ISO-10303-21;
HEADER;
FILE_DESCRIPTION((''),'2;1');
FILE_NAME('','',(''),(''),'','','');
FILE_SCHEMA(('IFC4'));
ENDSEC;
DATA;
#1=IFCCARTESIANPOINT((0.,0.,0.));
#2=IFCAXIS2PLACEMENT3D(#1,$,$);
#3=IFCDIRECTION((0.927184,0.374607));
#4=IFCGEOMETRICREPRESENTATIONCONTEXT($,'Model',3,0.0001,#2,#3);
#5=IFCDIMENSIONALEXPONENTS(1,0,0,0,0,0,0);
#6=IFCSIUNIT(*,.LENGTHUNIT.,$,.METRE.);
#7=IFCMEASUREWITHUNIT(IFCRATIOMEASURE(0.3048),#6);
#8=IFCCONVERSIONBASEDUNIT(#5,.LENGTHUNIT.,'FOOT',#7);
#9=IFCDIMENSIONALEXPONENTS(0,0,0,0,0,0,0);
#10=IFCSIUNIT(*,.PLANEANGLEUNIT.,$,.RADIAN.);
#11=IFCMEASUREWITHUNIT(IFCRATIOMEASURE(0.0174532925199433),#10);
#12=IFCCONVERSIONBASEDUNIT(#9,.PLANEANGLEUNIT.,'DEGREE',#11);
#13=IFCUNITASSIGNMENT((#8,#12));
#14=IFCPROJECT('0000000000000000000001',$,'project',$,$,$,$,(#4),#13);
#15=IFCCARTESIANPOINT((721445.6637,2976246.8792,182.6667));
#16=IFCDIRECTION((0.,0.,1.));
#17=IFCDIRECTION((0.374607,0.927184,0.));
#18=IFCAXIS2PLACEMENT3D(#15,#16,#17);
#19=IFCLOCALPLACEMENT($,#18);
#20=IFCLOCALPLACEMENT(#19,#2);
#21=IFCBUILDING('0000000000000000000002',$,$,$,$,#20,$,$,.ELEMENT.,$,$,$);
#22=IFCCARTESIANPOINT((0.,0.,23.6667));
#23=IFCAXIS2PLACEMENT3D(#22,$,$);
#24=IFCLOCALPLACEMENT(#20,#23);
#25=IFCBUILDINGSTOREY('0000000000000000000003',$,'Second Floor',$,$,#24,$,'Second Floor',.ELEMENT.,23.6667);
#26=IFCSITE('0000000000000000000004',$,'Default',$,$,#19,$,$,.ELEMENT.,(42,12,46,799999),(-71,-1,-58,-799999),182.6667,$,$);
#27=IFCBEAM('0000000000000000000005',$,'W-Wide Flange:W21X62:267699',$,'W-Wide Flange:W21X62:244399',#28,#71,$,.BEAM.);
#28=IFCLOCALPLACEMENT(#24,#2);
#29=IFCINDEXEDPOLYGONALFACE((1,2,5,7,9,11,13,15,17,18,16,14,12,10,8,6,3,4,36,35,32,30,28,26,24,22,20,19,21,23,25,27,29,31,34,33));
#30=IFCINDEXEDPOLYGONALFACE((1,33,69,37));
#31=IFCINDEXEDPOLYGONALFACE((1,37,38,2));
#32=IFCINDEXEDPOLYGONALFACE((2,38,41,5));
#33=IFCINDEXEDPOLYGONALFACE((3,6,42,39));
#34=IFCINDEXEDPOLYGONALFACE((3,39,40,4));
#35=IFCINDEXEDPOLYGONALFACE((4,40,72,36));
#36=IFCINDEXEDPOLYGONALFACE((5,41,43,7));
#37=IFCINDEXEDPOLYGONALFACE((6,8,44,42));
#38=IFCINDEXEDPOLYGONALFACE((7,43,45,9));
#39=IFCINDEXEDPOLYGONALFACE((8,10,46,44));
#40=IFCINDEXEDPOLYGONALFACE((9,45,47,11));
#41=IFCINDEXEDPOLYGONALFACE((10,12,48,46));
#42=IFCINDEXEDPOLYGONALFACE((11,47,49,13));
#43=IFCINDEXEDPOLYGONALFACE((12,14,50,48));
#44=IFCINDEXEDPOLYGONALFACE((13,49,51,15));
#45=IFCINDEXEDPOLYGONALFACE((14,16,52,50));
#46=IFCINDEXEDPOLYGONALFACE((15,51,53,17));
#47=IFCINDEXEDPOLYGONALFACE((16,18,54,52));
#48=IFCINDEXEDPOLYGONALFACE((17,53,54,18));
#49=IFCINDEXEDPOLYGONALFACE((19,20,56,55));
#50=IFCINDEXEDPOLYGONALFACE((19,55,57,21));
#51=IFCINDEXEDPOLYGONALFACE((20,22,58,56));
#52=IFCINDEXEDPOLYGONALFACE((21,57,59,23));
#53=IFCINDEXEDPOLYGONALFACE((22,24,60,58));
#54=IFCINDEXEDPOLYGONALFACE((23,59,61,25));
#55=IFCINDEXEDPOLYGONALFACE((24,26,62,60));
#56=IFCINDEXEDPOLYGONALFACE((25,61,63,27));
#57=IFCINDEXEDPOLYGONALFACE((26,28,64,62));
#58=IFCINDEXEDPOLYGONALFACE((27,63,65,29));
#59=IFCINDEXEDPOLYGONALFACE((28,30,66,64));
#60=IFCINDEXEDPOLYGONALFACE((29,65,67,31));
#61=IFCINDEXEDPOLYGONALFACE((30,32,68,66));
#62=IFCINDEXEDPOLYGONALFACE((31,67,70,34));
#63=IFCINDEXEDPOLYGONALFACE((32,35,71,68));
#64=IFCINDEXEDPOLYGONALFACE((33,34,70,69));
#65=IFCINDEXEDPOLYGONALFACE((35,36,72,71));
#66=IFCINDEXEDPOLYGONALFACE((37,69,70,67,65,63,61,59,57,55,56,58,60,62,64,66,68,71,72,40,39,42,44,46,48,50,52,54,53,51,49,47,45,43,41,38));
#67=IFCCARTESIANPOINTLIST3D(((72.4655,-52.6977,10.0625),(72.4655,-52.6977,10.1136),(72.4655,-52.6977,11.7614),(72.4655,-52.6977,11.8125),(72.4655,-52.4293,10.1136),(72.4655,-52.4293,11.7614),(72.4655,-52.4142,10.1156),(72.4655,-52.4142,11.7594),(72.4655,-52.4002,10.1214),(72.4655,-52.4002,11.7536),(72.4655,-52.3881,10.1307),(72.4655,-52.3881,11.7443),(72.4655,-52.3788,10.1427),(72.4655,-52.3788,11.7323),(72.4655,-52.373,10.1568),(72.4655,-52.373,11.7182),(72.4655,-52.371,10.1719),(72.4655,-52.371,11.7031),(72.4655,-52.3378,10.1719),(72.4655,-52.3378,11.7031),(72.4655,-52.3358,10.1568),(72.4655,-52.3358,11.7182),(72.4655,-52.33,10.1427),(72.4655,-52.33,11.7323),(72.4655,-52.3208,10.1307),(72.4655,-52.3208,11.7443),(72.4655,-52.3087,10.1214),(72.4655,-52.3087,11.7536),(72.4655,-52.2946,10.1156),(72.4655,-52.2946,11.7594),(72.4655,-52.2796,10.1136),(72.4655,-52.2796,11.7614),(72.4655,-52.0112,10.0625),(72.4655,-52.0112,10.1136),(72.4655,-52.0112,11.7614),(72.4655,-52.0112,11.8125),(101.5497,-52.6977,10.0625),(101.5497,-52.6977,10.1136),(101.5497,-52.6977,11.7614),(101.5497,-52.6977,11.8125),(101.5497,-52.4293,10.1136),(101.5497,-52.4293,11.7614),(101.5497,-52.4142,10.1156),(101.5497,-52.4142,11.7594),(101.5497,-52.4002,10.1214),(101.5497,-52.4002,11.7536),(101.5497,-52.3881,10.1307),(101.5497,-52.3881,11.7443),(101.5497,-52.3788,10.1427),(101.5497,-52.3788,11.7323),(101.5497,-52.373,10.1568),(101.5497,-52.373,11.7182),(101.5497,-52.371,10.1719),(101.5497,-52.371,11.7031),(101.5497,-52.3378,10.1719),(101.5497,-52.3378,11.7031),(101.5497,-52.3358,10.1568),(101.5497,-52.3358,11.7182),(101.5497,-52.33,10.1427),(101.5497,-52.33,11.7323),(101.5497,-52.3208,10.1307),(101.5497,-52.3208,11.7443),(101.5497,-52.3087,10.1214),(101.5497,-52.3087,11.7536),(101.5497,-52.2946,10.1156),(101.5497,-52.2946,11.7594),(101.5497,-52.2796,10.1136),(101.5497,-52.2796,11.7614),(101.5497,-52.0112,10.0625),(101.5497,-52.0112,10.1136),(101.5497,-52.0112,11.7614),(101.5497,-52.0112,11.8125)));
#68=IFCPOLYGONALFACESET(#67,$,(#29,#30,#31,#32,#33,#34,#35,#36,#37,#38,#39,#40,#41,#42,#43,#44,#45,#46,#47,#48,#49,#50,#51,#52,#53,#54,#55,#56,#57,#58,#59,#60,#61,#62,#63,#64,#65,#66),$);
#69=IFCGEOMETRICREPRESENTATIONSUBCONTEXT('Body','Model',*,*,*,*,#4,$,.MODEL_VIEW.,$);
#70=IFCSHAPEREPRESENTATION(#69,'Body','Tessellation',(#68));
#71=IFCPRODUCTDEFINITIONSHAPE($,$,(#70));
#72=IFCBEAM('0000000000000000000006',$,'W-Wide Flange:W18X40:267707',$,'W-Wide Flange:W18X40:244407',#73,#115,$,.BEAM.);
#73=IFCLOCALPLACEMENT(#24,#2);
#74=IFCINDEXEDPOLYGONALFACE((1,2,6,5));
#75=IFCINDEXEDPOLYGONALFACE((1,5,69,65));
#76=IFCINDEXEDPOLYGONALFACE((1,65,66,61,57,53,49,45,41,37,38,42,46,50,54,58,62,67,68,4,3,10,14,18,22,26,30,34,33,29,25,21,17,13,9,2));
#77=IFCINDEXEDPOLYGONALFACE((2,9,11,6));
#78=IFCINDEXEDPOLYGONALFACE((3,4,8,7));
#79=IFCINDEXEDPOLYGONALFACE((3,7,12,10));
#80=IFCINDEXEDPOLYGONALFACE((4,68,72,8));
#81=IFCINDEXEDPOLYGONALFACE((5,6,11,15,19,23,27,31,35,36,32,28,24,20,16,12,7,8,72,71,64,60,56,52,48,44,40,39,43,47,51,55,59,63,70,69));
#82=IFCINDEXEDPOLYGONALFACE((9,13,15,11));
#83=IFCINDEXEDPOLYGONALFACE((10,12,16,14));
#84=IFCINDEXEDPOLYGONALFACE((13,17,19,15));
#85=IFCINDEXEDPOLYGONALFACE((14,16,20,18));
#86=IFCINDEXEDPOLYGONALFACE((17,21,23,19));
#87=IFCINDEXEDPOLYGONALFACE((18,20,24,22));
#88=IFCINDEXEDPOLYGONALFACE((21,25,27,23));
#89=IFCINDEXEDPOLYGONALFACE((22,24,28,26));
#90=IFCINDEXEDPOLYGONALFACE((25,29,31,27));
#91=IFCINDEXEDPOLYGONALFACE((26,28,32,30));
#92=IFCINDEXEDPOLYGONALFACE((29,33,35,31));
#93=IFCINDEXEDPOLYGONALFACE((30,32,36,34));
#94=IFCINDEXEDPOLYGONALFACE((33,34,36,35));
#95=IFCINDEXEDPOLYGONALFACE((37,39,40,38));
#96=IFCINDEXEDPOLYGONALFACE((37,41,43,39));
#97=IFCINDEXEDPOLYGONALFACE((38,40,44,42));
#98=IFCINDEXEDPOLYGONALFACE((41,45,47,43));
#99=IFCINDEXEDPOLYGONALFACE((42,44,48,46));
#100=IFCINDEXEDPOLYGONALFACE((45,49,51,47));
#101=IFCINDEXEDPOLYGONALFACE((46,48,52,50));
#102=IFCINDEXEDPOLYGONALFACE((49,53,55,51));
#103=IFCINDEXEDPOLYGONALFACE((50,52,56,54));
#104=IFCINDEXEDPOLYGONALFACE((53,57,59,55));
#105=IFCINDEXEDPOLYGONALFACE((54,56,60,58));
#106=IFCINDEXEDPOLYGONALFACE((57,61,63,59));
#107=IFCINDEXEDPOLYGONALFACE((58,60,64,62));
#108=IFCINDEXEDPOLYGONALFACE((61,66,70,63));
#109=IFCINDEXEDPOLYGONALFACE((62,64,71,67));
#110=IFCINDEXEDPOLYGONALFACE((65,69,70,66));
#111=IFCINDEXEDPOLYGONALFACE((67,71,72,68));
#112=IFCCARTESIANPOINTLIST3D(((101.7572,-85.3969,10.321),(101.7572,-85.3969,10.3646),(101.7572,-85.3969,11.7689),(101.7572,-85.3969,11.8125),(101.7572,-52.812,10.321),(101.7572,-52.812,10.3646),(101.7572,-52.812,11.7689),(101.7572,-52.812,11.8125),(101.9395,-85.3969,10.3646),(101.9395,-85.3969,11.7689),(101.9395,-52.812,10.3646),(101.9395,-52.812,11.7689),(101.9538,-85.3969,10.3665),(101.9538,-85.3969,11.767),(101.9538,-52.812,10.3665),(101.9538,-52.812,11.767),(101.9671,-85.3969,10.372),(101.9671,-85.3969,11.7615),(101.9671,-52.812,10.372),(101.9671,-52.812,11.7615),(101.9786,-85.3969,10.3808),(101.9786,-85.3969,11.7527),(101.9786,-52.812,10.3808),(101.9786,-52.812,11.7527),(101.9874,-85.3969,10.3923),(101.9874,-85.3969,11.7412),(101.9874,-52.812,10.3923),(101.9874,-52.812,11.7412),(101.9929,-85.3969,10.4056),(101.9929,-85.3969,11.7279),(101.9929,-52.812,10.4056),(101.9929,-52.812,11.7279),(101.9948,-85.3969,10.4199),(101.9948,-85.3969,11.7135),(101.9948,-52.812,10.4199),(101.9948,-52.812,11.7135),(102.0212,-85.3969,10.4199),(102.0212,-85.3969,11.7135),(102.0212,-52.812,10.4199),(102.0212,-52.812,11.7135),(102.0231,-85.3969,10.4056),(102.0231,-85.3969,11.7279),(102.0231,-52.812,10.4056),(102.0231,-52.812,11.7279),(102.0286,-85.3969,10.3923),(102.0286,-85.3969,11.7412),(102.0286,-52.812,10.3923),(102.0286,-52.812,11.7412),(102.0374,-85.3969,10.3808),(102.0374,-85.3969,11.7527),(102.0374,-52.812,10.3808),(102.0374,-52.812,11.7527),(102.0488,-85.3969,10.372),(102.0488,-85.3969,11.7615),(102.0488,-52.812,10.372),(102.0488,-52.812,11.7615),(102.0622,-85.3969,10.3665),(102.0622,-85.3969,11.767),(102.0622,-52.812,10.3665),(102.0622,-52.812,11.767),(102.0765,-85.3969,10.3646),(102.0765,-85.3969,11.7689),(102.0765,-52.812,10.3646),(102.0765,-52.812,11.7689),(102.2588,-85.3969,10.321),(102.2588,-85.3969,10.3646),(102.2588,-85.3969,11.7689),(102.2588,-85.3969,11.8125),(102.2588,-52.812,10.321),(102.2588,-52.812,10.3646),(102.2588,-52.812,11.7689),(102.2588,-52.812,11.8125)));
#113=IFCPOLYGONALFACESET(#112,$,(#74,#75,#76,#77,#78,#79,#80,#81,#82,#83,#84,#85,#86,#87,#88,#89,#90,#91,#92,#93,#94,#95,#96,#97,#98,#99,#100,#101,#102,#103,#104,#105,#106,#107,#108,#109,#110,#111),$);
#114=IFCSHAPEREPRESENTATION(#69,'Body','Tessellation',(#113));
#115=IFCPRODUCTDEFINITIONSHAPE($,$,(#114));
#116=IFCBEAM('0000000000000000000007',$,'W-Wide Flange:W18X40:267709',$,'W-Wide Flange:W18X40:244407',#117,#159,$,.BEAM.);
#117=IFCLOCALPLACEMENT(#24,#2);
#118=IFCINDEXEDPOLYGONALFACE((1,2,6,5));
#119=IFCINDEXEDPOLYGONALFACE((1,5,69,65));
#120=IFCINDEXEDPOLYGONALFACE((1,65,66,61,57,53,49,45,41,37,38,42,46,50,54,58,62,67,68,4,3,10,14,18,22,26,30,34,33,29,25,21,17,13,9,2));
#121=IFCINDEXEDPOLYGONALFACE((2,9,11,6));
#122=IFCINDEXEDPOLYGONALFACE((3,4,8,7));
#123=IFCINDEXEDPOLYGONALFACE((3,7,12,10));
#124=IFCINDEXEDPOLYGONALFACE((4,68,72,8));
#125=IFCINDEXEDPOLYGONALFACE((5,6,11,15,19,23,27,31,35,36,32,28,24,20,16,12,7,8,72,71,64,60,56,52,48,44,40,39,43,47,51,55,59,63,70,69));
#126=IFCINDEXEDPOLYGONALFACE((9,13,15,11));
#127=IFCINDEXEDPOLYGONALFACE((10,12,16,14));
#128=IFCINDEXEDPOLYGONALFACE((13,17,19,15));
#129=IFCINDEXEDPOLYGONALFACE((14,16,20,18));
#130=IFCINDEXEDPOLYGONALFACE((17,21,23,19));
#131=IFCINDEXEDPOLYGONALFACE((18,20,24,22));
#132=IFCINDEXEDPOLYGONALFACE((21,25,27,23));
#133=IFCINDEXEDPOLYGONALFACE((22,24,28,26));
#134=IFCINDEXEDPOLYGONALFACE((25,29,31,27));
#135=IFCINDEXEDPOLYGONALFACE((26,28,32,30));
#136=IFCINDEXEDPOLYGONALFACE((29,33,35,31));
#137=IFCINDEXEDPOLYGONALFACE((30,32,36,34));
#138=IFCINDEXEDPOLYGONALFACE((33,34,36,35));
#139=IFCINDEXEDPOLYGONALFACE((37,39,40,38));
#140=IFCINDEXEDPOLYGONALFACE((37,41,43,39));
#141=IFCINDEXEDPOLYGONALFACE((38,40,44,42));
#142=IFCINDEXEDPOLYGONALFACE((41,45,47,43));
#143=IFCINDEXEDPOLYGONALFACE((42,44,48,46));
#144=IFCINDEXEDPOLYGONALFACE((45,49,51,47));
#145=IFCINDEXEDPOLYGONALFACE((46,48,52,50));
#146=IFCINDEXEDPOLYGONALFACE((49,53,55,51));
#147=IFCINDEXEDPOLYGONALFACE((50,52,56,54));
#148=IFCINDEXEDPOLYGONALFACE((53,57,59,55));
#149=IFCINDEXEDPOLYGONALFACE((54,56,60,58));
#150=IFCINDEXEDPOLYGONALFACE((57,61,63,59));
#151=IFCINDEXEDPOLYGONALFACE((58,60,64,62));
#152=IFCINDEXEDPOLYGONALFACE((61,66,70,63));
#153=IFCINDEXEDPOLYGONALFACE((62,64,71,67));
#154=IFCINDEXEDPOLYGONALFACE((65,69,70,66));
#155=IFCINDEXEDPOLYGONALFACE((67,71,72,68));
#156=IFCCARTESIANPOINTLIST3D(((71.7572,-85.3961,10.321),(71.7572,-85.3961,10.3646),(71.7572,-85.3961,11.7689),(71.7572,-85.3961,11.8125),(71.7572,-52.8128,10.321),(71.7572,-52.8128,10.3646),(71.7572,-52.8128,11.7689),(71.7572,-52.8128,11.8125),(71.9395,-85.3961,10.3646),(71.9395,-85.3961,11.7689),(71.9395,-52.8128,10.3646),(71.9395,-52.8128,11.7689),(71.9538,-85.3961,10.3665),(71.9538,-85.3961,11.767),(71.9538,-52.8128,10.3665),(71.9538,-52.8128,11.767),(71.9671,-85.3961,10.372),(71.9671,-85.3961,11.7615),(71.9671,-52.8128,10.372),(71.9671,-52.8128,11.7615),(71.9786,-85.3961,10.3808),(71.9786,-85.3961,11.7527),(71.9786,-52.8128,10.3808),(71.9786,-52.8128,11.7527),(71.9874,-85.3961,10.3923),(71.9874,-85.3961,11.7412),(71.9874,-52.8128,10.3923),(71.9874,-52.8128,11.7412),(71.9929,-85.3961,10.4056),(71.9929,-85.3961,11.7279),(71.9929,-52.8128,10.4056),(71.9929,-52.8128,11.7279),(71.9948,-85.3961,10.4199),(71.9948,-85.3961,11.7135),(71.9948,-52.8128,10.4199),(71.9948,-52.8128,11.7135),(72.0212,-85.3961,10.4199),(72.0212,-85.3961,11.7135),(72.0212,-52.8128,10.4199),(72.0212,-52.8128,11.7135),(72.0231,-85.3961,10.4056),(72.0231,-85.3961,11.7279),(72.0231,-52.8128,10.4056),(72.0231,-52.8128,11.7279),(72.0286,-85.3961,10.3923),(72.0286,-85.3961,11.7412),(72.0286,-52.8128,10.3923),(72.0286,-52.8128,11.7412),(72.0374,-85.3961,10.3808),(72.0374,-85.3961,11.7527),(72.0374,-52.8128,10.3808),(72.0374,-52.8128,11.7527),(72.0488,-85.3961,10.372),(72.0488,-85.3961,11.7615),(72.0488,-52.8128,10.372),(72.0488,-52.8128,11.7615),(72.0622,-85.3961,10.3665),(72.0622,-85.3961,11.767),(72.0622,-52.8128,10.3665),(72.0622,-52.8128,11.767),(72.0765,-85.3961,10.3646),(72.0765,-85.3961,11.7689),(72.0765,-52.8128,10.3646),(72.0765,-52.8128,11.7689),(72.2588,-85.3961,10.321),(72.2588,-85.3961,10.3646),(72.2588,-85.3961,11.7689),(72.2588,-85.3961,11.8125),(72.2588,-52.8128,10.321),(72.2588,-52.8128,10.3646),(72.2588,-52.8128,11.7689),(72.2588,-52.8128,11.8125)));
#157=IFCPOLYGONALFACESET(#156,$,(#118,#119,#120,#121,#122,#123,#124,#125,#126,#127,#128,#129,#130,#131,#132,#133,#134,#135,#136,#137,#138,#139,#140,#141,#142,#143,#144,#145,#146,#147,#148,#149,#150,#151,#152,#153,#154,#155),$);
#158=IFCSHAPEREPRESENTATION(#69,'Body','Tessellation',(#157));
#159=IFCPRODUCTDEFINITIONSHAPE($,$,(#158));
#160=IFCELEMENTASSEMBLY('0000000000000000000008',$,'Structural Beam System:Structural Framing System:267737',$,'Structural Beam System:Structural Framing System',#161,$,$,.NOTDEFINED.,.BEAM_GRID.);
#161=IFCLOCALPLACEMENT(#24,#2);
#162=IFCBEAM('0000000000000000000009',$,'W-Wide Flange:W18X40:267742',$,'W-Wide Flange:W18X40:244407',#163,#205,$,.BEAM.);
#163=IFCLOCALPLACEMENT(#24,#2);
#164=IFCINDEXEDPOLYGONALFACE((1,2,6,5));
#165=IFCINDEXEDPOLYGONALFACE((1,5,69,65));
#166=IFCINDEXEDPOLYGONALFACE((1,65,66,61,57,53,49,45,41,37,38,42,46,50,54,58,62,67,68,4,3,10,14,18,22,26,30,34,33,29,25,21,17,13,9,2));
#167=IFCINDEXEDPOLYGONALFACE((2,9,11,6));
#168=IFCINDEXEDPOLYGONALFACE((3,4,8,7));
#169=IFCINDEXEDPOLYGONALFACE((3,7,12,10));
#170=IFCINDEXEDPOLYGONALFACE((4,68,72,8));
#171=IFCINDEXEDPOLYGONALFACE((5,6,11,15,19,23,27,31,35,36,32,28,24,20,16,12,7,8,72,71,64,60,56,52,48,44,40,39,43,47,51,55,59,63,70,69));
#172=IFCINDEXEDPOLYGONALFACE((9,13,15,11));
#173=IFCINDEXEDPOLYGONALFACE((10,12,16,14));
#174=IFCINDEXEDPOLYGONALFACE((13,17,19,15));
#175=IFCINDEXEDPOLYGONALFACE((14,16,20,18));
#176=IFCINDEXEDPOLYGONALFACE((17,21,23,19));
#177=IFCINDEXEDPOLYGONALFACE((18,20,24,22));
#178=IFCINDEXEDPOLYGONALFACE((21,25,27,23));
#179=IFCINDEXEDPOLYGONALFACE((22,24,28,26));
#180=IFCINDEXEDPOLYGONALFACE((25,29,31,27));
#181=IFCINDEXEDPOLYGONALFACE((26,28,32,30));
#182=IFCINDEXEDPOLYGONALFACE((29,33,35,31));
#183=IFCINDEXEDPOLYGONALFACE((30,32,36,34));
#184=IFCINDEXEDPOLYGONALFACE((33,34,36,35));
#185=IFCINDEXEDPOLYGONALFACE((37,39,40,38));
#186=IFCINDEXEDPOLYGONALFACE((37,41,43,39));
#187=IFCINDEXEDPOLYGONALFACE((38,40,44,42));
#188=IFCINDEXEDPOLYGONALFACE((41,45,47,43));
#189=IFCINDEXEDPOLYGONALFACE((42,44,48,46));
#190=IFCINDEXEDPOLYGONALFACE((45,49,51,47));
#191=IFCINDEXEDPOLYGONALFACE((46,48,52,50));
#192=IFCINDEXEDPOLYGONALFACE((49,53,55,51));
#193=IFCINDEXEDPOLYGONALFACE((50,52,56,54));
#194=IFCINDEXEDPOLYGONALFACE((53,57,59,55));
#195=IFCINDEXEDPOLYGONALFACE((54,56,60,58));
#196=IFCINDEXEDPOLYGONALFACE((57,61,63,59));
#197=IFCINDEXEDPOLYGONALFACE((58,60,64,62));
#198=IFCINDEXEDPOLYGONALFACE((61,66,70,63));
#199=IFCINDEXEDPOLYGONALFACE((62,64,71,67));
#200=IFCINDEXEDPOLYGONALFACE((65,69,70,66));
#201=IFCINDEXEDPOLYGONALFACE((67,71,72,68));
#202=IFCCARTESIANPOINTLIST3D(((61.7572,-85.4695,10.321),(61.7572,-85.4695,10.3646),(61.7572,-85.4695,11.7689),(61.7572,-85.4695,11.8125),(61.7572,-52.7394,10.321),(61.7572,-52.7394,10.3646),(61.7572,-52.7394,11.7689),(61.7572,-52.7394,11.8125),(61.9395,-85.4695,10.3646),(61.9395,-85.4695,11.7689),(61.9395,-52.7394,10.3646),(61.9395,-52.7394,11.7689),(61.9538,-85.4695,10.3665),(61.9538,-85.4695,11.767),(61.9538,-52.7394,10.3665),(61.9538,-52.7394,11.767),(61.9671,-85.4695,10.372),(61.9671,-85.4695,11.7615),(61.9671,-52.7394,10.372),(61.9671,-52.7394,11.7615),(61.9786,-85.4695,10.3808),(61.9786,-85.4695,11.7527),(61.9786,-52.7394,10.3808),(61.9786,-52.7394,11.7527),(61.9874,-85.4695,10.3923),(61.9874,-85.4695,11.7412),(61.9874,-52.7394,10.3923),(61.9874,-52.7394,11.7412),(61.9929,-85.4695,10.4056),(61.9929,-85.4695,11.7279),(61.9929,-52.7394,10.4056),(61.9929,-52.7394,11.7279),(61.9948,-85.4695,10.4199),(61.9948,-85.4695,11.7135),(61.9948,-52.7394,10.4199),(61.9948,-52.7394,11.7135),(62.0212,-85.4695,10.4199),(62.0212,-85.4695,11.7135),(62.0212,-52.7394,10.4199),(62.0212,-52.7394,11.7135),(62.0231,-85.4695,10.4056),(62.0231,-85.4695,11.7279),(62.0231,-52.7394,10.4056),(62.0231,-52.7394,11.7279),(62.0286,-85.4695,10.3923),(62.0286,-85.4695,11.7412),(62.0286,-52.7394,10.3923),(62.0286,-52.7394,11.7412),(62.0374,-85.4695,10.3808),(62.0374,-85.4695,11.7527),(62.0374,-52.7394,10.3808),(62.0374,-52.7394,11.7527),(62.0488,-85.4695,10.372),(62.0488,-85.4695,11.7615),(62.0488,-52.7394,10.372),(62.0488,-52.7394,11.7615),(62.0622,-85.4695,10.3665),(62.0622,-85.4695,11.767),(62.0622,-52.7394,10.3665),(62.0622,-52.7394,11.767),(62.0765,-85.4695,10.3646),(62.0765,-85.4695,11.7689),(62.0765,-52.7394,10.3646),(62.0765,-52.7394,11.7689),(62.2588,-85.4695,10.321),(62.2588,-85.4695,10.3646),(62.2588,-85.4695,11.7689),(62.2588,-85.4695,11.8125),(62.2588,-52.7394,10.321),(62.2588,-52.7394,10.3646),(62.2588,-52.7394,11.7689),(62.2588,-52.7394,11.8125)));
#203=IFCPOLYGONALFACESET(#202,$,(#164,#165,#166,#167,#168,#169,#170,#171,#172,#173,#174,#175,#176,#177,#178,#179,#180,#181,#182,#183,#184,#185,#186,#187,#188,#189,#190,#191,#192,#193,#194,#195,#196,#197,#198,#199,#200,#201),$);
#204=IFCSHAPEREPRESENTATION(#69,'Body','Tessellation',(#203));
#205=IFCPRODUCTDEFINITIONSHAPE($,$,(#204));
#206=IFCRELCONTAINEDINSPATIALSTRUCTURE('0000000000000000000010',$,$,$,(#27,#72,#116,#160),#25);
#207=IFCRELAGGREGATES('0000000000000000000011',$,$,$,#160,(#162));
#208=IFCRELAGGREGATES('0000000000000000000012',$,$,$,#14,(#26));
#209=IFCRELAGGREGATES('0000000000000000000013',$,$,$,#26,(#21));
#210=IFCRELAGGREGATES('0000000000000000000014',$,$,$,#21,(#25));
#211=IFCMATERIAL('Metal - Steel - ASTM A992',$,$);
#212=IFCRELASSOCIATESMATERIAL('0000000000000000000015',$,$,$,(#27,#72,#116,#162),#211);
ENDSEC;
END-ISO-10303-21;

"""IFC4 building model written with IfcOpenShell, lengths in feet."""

from ifc_helpers import new_model, entity, si_unit, converted_unit, direction, frame, frame_2d, origin, place, context, subcontext, project, spatial, i_section, extrude, material, element, aggregate, save


model = new_model("IFC4")

# Units and contexts
model_context = context("Model", 3, precision=0.0001, world=origin(), true_north=direction((0.927184, 0.374607)))
body_context = subcontext(model_context, "Body", "Model", "MODEL_VIEW")
ifc_project = project(units=[converted_unit("LENGTHUNIT", "FOOT", entity("IfcRatioMeasure", 0.3048), si_unit("LENGTHUNIT", "METRE"), dimensions=[1, 0, 0, 0, 0, 0, 0]), converted_unit("PLANEANGLEUNIT", "DEGREE", entity("IfcRatioMeasure", 0.0174532925199433), si_unit("PLANEANGLEUNIT", "RADIAN"), dimensions=[0, 0, 0, 0, 0, 0, 0])], contexts=[model_context])

# Site, building, storey
site_placement = place(None, frame((721445.6637, 2976246.8792, 182.6667), z_axis=(0.0, 0.0, 1.0), x_axis=(0.374607, 0.927184, 0.0)))
site = spatial("IfcSite", under=ifc_project, at=site_placement, Name="Default", CompositionType="ELEMENT", RefLatitude=(42, 12, 46, 799999), RefLongitude=(-71, -1, -58, -799999), RefElevation=182.6667)
building_placement = place(site_placement, origin())
building = spatial("IfcBuilding", under=site, at=building_placement, CompositionType="ELEMENT")
storey_placement = place(building_placement, frame((0.0, 0.0, 23.6667)))
storey = spatial("IfcBuildingStorey", under=building, at=storey_placement, Name="Second Floor", LongName="Second Floor", CompositionType="ELEMENT", Elevation=23.6667)

# Shared definitions
ifc_material_1 = material(Name="Metal - Steel - ASTM A992")

# Beams
beam_1_placement = place(storey_placement, frame((102.008, -52.3544, 11.8125), z_axis=(0.0, 0.0, 1.0), x_axis=(-1.0, 0.0, 0.0)))
element("IfcBeam", 1, at=beam_1_placement, inside=storey, material=ifc_material_1, Name="W-Wide Flange:W21X62:267699", ObjectType="W-Wide Flange:W21X62:244399", PredefinedType="BEAM", context=body_context, shape_type="SweptSolid", body=[
    extrude(i_section(OverallWidth=0.6865, OverallDepth=1.75, WebThickness=0.0332, FlangeThickness=0.0511, FilletRadius=0.0583, at=frame_2d((0.0, 0.0), x_axis=(0.0, 1.0))), frame((0.4583, 0.0, -0.875), z_axis=(1.0, 0.0, 0.0), x_axis=(0.0, 0.0, -1.0)), (0.0, 0.0, 1.0), 29.0841),
])
beam_2_placement = place(storey_placement, frame((102.008, -52.3544, 11.8125), z_axis=(0.0, 0.0, 1.0), x_axis=(0.0, -1.0, 0.0)))
element("IfcBeam", 2, at=beam_2_placement, inside=storey, material=ifc_material_1, Name="W-Wide Flange:W18X40:267707", ObjectType="W-Wide Flange:W18X40:244407", PredefinedType="BEAM", context=body_context, shape_type="SweptSolid", body=[
    extrude(i_section(OverallWidth=0.5016, OverallDepth=1.4915, WebThickness=0.0264, FlangeThickness=0.0436, FilletRadius=0.0553, at=frame_2d((0.0, 0.0), x_axis=(0.0, 1.0))), frame((0.4575, 0.0, -0.7458), z_axis=(1.0, 0.0, 0.0), x_axis=(0.0, 0.0, -1.0)), (0.0, 0.0, 1.0), 32.585),
])
beam_3_placement = place(storey_placement, frame((72.008, -52.3544, 11.8125), z_axis=(0.0, 0.0, 1.0), x_axis=(0.0, -1.0, 0.0)))
element("IfcBeam", 3, at=beam_3_placement, inside=storey, material=ifc_material_1, Name="W-Wide Flange:W18X40:267709", ObjectType="W-Wide Flange:W18X40:244407", PredefinedType="BEAM", context=body_context, shape_type="SweptSolid", body=[
    extrude(i_section(OverallWidth=0.5016, OverallDepth=1.4915, WebThickness=0.0264, FlangeThickness=0.0436, FilletRadius=0.0553, at=frame_2d((0.0, 0.0), x_axis=(0.0, 1.0))), frame((0.4583, 0.0, -0.7458), z_axis=(1.0, 0.0, 0.0), x_axis=(0.0, 0.0, -1.0)), (0.0, 0.0, 1.0), 32.5833),
])

# Element assembly, beam
assembly_1_placement = place(storey_placement, origin())
assembly_1 = element("IfcElementAssembly", 4, at=assembly_1_placement, inside=storey, Name="Structural Beam System:Structural Framing System:267737", ObjectType="Structural Beam System:Structural Framing System", AssemblyPlace="NOTDEFINED", PredefinedType="BEAM_GRID")
beam_4_placement = place(assembly_1_placement, frame((62.008, -52.3544, 11.8125), z_axis=(0.0, 0.0, 1.0), x_axis=(0.0, -1.0, 0.0)))
beam_4 = element("IfcBeam", 5, at=beam_4_placement, material=ifc_material_1, Name="W-Wide Flange:W18X40:267742", ObjectType="W-Wide Flange:W18X40:244407", PredefinedType="BEAM", context=body_context, shape_type="SweptSolid", body=[
    extrude(i_section(OverallWidth=0.5016, OverallDepth=1.4915, WebThickness=0.0264, FlangeThickness=0.0436, FilletRadius=0.0553, at=frame_2d((0.0, 0.0), x_axis=(0.0, 1.0))), frame((0.3849, 0.0, -0.7458), z_axis=(1.0, 0.0, 0.0), x_axis=(0.0, 0.0, -1.0)), (0.0, 0.0, 1.0), 32.7301),
])
aggregate(assembly_1, [beam_4])

save(model, "model.ifc")
